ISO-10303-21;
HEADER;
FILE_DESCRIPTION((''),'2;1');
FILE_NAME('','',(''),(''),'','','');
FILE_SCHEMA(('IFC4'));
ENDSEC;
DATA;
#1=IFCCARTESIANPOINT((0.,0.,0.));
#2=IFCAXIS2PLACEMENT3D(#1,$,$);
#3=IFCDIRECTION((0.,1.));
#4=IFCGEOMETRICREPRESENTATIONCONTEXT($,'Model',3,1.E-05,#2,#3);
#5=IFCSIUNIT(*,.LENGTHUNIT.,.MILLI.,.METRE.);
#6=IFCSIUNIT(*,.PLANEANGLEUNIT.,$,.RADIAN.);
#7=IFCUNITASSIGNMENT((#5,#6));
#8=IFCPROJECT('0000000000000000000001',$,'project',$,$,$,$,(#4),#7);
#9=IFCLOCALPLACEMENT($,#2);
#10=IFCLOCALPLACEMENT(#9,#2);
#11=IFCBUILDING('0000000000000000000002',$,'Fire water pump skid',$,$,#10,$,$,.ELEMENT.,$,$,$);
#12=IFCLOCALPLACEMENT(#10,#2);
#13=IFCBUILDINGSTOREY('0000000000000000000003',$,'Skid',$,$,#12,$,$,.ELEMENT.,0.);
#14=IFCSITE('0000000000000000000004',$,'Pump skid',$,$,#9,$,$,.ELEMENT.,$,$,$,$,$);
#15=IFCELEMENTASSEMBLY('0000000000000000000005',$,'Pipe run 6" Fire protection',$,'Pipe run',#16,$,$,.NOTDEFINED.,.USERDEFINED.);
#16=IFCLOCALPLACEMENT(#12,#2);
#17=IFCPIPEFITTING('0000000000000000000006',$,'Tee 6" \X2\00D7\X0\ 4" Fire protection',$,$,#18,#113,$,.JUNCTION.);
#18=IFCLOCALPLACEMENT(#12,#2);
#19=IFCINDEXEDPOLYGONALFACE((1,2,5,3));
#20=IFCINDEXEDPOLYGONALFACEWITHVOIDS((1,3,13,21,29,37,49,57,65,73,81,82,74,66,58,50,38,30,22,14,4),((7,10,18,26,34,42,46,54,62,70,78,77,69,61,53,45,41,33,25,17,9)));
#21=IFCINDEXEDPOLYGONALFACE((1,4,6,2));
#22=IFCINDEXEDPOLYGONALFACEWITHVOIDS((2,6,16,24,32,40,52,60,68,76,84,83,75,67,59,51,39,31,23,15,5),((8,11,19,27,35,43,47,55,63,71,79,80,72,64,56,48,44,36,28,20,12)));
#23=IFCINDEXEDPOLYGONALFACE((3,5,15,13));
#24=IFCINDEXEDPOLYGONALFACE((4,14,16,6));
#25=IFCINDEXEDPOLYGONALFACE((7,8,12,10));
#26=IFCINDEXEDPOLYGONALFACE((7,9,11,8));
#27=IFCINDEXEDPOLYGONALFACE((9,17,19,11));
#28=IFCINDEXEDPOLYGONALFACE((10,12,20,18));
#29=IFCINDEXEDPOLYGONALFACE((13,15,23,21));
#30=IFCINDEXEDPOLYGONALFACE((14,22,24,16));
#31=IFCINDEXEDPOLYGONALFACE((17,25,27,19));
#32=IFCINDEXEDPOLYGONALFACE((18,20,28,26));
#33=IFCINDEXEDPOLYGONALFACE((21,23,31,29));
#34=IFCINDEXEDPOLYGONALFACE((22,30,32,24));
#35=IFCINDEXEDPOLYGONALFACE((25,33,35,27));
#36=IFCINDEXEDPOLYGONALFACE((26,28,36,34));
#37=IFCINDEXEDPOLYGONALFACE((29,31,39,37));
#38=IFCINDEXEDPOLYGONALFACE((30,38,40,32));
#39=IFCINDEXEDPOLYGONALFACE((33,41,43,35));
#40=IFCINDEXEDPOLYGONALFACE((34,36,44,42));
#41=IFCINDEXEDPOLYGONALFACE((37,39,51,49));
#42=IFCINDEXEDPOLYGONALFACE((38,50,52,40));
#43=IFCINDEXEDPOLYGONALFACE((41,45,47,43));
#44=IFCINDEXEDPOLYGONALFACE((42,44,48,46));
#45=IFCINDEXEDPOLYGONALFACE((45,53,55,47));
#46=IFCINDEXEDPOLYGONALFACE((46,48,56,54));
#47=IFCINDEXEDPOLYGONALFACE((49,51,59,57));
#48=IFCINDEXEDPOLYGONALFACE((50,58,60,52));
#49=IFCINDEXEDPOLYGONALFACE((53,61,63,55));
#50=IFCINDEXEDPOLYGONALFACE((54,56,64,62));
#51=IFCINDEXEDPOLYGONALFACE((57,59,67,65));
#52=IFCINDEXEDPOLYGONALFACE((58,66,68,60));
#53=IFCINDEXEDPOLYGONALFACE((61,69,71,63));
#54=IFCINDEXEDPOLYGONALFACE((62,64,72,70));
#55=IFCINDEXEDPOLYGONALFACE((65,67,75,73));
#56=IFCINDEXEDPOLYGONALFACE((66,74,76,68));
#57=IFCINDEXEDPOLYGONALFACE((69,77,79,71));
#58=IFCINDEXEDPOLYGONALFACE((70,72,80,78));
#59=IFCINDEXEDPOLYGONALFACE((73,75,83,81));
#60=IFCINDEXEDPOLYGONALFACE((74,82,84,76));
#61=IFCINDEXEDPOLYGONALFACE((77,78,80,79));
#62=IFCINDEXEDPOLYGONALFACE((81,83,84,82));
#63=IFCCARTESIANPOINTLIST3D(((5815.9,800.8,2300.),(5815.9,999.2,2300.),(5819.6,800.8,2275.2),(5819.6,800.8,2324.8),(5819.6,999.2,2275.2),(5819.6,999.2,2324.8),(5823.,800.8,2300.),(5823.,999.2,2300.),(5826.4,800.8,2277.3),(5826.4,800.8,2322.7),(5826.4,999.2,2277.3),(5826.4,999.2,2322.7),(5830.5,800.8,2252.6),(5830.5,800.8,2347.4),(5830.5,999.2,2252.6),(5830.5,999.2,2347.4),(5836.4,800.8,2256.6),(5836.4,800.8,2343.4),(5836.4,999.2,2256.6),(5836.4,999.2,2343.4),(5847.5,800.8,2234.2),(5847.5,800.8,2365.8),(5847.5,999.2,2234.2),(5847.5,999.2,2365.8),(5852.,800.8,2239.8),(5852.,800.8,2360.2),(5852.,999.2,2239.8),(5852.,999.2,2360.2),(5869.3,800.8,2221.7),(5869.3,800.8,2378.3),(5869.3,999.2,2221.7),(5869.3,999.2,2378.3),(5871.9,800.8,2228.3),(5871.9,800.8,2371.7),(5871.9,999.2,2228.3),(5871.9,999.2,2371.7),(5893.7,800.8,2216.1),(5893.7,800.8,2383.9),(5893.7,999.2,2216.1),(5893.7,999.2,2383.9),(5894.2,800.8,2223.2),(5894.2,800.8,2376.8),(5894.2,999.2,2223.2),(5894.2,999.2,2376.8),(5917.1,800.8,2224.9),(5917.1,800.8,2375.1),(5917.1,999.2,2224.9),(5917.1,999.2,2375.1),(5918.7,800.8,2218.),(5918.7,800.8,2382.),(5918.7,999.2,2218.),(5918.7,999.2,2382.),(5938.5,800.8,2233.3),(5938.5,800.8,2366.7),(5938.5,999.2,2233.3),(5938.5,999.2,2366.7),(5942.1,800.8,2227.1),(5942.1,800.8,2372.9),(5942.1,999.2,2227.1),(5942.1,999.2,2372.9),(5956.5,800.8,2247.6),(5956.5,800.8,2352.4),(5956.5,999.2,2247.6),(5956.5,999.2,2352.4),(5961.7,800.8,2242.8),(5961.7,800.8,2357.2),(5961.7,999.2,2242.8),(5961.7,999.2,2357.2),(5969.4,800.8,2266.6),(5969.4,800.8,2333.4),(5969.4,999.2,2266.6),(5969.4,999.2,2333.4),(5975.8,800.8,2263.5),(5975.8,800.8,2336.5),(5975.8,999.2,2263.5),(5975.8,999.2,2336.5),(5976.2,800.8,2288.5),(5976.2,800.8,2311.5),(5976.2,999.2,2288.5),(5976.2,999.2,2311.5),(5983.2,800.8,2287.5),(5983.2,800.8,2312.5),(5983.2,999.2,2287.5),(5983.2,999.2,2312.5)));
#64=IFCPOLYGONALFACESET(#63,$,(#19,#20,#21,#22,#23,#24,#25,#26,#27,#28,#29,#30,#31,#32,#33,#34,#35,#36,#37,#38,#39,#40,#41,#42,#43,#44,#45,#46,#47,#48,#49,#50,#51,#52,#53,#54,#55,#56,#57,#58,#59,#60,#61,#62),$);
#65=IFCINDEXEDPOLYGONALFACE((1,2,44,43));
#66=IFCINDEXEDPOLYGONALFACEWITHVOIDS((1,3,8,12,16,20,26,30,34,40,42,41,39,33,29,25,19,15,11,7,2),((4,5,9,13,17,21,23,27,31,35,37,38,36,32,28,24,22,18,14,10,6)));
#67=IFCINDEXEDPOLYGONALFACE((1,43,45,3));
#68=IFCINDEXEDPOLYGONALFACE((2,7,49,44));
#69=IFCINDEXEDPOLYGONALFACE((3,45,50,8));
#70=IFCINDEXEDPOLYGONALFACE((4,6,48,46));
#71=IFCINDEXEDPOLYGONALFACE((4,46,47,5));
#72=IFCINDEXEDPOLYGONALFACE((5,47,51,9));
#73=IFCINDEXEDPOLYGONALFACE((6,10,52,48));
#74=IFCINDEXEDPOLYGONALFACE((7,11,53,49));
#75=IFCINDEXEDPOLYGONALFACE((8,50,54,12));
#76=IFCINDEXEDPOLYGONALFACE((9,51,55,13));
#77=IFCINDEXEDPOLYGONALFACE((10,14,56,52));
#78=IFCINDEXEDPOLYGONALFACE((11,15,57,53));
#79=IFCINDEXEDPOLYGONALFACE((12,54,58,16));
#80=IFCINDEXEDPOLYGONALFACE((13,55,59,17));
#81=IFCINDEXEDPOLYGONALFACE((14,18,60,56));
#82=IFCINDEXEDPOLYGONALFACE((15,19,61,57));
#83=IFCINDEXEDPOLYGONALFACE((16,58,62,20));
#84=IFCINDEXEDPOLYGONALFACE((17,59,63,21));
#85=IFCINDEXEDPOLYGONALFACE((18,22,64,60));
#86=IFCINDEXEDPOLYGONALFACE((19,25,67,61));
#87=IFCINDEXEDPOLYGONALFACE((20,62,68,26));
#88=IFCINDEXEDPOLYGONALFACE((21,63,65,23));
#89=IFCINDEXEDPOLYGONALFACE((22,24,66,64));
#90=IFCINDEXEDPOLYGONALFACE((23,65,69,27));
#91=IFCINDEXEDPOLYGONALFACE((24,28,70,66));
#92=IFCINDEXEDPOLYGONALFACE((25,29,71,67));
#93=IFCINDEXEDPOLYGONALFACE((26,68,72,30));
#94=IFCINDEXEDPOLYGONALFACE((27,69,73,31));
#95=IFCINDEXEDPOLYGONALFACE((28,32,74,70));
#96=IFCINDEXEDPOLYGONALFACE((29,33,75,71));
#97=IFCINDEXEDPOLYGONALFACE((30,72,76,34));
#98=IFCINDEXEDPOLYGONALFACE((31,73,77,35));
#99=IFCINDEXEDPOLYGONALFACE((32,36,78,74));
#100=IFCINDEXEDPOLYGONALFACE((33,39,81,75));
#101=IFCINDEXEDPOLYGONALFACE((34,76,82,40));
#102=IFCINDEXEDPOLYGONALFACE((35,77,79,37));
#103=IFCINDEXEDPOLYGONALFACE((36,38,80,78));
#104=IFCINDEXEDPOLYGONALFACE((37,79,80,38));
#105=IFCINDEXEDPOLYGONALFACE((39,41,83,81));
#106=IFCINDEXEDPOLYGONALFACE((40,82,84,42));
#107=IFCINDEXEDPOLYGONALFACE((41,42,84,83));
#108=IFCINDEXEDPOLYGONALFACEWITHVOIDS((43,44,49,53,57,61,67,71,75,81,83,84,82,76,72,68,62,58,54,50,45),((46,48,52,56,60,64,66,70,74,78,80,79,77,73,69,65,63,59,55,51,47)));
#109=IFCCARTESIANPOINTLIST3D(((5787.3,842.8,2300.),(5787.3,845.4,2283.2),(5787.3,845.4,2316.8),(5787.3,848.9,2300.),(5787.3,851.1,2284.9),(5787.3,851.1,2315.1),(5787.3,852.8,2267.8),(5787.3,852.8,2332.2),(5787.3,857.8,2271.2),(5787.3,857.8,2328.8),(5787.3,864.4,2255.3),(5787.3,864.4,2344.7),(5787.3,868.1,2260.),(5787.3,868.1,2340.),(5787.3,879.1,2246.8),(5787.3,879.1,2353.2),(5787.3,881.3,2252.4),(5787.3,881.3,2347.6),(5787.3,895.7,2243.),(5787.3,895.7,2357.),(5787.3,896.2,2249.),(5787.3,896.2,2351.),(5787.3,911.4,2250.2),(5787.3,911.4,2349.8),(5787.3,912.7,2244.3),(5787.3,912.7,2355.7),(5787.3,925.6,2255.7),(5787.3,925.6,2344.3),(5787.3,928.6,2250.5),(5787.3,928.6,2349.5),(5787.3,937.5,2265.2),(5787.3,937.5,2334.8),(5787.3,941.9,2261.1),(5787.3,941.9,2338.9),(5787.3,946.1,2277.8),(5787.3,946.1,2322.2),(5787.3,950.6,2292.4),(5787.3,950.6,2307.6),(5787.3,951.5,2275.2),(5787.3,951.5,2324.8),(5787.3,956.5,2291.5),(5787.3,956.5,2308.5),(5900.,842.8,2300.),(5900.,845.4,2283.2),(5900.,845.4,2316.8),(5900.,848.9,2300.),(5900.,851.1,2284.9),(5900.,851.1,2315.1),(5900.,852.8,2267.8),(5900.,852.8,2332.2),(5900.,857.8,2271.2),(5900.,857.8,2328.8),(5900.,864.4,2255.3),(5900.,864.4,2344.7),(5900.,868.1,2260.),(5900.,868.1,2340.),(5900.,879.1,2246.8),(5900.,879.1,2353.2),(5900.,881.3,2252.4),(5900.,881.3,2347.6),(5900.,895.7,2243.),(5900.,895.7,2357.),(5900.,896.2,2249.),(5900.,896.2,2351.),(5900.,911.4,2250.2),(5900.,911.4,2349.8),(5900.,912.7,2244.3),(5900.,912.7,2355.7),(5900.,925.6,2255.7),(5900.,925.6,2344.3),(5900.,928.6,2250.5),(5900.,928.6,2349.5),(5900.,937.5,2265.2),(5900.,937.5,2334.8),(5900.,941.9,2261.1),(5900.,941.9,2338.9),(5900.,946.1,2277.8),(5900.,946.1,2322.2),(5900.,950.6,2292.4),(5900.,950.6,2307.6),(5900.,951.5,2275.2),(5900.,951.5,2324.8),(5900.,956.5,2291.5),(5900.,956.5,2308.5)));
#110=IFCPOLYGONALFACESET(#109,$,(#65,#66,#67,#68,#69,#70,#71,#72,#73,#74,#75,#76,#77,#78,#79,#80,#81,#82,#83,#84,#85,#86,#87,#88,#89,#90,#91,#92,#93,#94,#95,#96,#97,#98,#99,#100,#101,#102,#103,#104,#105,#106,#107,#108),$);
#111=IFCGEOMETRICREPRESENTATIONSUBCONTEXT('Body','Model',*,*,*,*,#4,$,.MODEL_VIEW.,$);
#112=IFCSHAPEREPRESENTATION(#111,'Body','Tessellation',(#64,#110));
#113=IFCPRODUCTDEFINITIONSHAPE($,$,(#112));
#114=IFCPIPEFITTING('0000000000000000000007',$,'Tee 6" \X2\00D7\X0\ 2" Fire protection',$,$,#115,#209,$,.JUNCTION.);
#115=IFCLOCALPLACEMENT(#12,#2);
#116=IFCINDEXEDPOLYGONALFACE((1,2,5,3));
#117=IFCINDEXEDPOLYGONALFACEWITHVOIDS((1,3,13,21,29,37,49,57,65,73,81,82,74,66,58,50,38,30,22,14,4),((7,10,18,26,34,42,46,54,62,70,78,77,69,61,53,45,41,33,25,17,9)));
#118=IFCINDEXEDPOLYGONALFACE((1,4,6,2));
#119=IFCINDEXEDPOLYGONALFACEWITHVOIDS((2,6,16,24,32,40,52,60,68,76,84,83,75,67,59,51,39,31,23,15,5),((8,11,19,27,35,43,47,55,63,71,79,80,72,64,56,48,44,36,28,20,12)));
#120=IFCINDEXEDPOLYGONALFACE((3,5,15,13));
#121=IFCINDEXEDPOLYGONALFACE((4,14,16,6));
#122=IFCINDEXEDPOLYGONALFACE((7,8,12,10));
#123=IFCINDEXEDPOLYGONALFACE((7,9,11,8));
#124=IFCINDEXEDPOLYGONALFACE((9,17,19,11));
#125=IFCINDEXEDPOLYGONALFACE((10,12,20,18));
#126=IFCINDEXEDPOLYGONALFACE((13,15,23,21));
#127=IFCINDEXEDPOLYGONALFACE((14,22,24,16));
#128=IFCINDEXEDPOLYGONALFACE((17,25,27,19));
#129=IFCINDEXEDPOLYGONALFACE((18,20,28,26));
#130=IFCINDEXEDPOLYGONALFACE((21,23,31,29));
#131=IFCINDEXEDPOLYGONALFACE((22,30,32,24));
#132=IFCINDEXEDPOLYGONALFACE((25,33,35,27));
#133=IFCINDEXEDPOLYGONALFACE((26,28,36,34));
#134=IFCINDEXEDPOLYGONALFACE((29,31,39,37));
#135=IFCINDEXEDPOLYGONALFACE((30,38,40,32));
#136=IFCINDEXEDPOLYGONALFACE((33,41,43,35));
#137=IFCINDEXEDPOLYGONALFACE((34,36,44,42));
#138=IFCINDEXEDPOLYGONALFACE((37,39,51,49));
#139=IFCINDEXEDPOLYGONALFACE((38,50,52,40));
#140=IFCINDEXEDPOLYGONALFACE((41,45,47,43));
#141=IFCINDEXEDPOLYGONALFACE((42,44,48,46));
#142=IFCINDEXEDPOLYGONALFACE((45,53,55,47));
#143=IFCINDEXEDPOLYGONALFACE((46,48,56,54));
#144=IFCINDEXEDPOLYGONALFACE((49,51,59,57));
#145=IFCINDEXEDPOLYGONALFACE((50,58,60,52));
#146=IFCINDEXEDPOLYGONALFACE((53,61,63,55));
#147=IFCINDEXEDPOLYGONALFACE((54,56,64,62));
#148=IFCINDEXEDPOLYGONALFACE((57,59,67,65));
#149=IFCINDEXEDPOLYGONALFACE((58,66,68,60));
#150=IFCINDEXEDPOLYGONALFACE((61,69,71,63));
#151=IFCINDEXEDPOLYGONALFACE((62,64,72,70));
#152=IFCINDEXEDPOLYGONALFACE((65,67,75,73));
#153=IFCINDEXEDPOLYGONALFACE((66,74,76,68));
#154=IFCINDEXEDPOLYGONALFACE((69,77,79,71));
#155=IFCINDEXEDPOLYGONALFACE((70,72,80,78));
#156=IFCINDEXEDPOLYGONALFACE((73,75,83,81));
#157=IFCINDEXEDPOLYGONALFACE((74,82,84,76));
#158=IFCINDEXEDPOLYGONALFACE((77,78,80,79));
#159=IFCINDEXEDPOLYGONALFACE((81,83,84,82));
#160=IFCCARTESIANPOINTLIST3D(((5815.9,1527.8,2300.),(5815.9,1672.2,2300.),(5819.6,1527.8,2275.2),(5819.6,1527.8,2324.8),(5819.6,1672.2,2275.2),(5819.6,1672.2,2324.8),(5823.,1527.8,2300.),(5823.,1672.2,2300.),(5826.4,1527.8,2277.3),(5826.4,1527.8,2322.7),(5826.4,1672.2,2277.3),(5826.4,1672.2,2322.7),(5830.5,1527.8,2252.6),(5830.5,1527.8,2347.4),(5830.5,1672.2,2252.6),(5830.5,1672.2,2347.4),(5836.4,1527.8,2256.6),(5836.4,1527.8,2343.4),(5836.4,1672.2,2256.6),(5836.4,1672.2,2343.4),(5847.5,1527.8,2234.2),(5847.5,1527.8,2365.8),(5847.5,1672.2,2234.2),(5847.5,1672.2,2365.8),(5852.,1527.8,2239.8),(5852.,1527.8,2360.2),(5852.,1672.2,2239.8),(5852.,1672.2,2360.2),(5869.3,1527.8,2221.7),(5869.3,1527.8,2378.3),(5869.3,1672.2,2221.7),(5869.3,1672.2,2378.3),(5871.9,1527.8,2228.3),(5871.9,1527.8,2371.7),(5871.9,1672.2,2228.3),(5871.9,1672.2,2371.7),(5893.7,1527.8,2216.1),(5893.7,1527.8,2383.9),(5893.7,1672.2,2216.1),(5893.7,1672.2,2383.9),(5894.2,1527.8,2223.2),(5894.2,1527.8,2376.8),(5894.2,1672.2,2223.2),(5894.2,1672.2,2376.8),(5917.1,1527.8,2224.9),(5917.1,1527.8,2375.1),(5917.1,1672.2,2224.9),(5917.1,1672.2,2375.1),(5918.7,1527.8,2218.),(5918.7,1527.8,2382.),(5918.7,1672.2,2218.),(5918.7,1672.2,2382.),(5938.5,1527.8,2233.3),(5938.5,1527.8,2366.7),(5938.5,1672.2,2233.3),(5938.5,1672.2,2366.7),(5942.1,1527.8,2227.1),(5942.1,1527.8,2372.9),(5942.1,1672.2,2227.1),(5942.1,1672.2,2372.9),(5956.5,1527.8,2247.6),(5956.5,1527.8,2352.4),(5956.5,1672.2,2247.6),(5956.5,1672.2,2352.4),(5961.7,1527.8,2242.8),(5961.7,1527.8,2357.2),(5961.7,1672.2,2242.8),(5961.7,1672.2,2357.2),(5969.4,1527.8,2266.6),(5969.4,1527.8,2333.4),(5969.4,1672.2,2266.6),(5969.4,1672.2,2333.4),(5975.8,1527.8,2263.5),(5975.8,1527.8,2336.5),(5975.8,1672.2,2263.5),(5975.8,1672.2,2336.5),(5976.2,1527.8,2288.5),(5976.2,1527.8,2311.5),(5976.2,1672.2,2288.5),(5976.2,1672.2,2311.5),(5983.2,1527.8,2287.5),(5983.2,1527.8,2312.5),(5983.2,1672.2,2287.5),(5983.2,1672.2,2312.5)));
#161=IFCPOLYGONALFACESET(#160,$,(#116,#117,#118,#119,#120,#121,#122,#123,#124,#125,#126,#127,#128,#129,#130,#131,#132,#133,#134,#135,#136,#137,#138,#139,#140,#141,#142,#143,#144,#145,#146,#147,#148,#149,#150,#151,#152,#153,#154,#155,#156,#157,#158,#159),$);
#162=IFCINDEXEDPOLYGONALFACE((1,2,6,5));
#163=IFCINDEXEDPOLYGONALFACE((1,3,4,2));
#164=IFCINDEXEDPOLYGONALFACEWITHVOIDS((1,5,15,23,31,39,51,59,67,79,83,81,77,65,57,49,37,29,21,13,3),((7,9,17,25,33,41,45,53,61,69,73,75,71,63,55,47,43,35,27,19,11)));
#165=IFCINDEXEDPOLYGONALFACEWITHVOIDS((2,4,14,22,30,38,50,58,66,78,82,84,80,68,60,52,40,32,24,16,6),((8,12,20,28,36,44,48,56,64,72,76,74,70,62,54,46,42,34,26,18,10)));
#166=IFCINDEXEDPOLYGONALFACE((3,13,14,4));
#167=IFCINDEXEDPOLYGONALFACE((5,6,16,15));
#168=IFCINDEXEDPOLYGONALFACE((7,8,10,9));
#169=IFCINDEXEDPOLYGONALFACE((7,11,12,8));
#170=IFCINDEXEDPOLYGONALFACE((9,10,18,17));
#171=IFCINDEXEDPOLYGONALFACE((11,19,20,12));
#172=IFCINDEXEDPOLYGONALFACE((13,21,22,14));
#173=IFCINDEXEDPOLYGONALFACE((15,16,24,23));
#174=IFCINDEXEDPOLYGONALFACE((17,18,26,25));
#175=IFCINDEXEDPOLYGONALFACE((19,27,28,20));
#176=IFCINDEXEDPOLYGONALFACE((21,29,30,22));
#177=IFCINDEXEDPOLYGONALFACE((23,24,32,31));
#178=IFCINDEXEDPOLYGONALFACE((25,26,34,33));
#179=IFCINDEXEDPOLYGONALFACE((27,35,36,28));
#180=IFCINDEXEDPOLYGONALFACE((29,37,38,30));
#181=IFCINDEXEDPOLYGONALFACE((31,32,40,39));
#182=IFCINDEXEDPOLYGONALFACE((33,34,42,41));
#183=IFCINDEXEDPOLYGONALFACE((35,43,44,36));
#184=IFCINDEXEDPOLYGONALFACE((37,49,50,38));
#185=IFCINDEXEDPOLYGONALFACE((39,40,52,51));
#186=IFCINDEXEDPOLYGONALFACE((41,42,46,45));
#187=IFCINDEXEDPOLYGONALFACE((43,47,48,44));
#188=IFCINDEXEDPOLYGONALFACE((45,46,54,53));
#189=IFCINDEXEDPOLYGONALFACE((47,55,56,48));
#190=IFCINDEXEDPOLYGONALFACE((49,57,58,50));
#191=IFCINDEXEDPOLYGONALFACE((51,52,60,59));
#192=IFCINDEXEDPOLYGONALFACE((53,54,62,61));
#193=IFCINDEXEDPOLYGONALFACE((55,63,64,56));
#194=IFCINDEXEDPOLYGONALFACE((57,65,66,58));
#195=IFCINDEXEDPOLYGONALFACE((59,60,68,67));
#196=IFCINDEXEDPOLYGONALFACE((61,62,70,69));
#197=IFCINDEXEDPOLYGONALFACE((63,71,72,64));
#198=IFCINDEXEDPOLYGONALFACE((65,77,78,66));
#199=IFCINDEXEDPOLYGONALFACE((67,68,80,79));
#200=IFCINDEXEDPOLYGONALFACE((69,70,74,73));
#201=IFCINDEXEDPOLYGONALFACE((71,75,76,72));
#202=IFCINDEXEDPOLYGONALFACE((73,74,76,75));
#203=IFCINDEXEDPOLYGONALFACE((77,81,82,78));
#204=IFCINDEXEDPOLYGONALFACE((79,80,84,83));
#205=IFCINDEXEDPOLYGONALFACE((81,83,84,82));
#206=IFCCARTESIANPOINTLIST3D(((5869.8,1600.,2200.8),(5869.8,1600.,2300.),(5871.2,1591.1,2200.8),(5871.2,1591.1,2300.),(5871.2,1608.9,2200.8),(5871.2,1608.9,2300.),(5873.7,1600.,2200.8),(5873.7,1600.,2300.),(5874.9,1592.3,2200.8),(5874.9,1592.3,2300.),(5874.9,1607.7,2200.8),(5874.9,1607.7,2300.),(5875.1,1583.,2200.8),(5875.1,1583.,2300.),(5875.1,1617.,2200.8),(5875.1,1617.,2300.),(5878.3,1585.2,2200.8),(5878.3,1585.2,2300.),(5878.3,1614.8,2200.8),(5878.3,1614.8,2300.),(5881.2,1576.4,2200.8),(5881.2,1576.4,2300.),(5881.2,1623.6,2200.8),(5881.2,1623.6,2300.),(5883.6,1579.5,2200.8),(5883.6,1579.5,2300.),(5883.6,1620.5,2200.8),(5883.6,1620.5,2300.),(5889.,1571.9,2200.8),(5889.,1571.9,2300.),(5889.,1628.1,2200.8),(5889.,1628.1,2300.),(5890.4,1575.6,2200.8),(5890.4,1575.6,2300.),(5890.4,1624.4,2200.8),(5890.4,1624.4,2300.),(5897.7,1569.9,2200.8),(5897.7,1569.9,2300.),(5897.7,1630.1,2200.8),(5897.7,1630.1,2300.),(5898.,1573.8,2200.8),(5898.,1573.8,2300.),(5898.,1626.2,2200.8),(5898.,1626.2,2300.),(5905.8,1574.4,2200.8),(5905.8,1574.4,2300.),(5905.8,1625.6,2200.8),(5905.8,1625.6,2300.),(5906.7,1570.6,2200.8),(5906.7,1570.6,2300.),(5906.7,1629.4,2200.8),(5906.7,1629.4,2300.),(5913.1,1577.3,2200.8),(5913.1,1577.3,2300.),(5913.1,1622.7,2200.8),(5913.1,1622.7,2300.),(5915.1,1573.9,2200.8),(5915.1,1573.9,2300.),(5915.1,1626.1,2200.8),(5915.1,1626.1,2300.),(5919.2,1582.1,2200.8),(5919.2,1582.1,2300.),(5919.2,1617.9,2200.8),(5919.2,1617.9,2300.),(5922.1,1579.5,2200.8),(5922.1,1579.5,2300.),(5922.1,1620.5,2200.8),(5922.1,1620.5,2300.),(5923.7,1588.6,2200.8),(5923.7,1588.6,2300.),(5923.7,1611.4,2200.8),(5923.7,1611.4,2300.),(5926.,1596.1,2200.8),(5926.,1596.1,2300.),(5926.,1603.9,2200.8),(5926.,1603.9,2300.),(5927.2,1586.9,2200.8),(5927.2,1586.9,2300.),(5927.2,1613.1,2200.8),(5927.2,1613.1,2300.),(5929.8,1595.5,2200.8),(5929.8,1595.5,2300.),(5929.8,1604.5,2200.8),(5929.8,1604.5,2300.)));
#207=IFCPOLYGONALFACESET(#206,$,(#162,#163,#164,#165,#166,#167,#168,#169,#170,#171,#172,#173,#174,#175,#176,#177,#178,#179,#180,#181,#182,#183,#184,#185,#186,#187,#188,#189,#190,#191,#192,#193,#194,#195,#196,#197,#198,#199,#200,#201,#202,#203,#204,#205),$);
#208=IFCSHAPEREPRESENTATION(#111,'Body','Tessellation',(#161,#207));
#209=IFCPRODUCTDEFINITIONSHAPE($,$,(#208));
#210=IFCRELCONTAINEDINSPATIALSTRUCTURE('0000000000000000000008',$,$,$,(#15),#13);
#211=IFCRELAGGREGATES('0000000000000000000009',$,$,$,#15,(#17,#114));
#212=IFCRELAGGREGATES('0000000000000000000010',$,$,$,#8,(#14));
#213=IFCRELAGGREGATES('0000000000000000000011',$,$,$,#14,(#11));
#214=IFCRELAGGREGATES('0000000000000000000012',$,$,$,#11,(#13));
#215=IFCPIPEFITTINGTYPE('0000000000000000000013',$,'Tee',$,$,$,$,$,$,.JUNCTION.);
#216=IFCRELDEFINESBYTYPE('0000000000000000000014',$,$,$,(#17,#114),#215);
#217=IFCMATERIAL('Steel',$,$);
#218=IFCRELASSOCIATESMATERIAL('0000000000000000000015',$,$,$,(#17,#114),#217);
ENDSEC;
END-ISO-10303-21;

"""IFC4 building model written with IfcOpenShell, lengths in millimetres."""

from ifc_helpers import new_model, si_unit, direction, frame, origin, origin_with_axes, origin_2d, place, context, subcontext, project, spatial, hollow_circle, extrude, material, type_object, element, aggregate, save


model = new_model("IFC4")

# Units and contexts
model_context = context("Model", 3, precision=1e-05, world=origin(), true_north=direction((0.0, 1.0)))
body_context = subcontext(model_context, "Body", "Model", "MODEL_VIEW")
ifc_project = project(units=[si_unit("LENGTHUNIT", "METRE", prefix="MILLI"), si_unit("PLANEANGLEUNIT", "RADIAN")], contexts=[model_context])

# Site, building, storey
site_placement = place(None, origin())
site = spatial("IfcSite", under=ifc_project, at=site_placement, Name="Pump skid", CompositionType="ELEMENT")
building_placement = place(site_placement, origin())
building = spatial("IfcBuilding", under=site, at=building_placement, Name="Fire water pump skid", CompositionType="ELEMENT")
storey_placement = place(building_placement, origin())
storey = spatial("IfcBuildingStorey", under=building, at=storey_placement, Name="Skid", CompositionType="ELEMENT", Elevation=0.0)

# Element assembly
ifc_material = material(Name="Steel")
assembly_1_placement = place(storey_placement, origin_with_axes())
assembly_1 = element("IfcElementAssembly", 1, at=assembly_1_placement, inside=storey, Name="Pipe run 6\" Fire protection", ObjectType="Pipe run", AssemblyPlace="NOTDEFINED", PredefinedType="USERDEFINED")

# Pipe fittings
pipe_fitting_type_1 = type_object("IfcPipeFittingType", Name="Tee", PredefinedType="JUNCTION")
pipe_fitting_1_placement = place(storey_placement, origin_with_axes())
pipe_fitting_1 = element("IfcPipeFitting", 2, at=pipe_fitting_1_placement, type_object=pipe_fitting_type_1, material=ifc_material, Name="Tee 6\" × 4\" Fire protection", PredefinedType="JUNCTION", context=body_context, shape_type="SweptSolid", body=[
    extrude(hollow_circle(Radius=84.1, WallThickness=7.1, at=origin_2d()), frame((5900.0, 800.8, 2300.0), z_axis=(0.0, 1.0, 0.0), x_axis=(-1.0, 0.0, 0.0)), (0.0, 0.0, 1.0), 198.4),
    extrude(hollow_circle(Radius=57.1, WallThickness=6.0, at=origin_2d()), frame((5900.0, 900.0, 2300.0), z_axis=(-1.0, 0.0, 0.0), x_axis=(0.0, -1.0, 0.0)), (0.0, 0.0, 1.0), 112.7),
])
pipe_fitting_2_placement = place(storey_placement, origin_with_axes())
pipe_fitting_2 = element("IfcPipeFitting", 3, at=pipe_fitting_2_placement, type_object=pipe_fitting_type_1, material=ifc_material, Name="Tee 6\" × 2\" Fire protection", PredefinedType="JUNCTION", context=body_context, shape_type="SweptSolid", body=[
    extrude(hollow_circle(Radius=84.1, WallThickness=7.1, at=origin_2d()), frame((5900.0, 1527.8, 2300.0), z_axis=(0.0, 1.0, 0.0), x_axis=(-1.0, 0.0, 0.0)), (0.0, 0.0, 1.0), 144.5),
    extrude(hollow_circle(Radius=30.2, WallThickness=3.9, at=origin_2d()), frame((5900.0, 1600.0, 2300.0), z_axis=(0.0, 0.0, -1.0), x_axis=(-1.0, 0.0, 0.0)), (0.0, 0.0, 1.0), 99.2),
])
aggregate(assembly_1, [pipe_fitting_1, pipe_fitting_2])

save(model, "model.ifc")
